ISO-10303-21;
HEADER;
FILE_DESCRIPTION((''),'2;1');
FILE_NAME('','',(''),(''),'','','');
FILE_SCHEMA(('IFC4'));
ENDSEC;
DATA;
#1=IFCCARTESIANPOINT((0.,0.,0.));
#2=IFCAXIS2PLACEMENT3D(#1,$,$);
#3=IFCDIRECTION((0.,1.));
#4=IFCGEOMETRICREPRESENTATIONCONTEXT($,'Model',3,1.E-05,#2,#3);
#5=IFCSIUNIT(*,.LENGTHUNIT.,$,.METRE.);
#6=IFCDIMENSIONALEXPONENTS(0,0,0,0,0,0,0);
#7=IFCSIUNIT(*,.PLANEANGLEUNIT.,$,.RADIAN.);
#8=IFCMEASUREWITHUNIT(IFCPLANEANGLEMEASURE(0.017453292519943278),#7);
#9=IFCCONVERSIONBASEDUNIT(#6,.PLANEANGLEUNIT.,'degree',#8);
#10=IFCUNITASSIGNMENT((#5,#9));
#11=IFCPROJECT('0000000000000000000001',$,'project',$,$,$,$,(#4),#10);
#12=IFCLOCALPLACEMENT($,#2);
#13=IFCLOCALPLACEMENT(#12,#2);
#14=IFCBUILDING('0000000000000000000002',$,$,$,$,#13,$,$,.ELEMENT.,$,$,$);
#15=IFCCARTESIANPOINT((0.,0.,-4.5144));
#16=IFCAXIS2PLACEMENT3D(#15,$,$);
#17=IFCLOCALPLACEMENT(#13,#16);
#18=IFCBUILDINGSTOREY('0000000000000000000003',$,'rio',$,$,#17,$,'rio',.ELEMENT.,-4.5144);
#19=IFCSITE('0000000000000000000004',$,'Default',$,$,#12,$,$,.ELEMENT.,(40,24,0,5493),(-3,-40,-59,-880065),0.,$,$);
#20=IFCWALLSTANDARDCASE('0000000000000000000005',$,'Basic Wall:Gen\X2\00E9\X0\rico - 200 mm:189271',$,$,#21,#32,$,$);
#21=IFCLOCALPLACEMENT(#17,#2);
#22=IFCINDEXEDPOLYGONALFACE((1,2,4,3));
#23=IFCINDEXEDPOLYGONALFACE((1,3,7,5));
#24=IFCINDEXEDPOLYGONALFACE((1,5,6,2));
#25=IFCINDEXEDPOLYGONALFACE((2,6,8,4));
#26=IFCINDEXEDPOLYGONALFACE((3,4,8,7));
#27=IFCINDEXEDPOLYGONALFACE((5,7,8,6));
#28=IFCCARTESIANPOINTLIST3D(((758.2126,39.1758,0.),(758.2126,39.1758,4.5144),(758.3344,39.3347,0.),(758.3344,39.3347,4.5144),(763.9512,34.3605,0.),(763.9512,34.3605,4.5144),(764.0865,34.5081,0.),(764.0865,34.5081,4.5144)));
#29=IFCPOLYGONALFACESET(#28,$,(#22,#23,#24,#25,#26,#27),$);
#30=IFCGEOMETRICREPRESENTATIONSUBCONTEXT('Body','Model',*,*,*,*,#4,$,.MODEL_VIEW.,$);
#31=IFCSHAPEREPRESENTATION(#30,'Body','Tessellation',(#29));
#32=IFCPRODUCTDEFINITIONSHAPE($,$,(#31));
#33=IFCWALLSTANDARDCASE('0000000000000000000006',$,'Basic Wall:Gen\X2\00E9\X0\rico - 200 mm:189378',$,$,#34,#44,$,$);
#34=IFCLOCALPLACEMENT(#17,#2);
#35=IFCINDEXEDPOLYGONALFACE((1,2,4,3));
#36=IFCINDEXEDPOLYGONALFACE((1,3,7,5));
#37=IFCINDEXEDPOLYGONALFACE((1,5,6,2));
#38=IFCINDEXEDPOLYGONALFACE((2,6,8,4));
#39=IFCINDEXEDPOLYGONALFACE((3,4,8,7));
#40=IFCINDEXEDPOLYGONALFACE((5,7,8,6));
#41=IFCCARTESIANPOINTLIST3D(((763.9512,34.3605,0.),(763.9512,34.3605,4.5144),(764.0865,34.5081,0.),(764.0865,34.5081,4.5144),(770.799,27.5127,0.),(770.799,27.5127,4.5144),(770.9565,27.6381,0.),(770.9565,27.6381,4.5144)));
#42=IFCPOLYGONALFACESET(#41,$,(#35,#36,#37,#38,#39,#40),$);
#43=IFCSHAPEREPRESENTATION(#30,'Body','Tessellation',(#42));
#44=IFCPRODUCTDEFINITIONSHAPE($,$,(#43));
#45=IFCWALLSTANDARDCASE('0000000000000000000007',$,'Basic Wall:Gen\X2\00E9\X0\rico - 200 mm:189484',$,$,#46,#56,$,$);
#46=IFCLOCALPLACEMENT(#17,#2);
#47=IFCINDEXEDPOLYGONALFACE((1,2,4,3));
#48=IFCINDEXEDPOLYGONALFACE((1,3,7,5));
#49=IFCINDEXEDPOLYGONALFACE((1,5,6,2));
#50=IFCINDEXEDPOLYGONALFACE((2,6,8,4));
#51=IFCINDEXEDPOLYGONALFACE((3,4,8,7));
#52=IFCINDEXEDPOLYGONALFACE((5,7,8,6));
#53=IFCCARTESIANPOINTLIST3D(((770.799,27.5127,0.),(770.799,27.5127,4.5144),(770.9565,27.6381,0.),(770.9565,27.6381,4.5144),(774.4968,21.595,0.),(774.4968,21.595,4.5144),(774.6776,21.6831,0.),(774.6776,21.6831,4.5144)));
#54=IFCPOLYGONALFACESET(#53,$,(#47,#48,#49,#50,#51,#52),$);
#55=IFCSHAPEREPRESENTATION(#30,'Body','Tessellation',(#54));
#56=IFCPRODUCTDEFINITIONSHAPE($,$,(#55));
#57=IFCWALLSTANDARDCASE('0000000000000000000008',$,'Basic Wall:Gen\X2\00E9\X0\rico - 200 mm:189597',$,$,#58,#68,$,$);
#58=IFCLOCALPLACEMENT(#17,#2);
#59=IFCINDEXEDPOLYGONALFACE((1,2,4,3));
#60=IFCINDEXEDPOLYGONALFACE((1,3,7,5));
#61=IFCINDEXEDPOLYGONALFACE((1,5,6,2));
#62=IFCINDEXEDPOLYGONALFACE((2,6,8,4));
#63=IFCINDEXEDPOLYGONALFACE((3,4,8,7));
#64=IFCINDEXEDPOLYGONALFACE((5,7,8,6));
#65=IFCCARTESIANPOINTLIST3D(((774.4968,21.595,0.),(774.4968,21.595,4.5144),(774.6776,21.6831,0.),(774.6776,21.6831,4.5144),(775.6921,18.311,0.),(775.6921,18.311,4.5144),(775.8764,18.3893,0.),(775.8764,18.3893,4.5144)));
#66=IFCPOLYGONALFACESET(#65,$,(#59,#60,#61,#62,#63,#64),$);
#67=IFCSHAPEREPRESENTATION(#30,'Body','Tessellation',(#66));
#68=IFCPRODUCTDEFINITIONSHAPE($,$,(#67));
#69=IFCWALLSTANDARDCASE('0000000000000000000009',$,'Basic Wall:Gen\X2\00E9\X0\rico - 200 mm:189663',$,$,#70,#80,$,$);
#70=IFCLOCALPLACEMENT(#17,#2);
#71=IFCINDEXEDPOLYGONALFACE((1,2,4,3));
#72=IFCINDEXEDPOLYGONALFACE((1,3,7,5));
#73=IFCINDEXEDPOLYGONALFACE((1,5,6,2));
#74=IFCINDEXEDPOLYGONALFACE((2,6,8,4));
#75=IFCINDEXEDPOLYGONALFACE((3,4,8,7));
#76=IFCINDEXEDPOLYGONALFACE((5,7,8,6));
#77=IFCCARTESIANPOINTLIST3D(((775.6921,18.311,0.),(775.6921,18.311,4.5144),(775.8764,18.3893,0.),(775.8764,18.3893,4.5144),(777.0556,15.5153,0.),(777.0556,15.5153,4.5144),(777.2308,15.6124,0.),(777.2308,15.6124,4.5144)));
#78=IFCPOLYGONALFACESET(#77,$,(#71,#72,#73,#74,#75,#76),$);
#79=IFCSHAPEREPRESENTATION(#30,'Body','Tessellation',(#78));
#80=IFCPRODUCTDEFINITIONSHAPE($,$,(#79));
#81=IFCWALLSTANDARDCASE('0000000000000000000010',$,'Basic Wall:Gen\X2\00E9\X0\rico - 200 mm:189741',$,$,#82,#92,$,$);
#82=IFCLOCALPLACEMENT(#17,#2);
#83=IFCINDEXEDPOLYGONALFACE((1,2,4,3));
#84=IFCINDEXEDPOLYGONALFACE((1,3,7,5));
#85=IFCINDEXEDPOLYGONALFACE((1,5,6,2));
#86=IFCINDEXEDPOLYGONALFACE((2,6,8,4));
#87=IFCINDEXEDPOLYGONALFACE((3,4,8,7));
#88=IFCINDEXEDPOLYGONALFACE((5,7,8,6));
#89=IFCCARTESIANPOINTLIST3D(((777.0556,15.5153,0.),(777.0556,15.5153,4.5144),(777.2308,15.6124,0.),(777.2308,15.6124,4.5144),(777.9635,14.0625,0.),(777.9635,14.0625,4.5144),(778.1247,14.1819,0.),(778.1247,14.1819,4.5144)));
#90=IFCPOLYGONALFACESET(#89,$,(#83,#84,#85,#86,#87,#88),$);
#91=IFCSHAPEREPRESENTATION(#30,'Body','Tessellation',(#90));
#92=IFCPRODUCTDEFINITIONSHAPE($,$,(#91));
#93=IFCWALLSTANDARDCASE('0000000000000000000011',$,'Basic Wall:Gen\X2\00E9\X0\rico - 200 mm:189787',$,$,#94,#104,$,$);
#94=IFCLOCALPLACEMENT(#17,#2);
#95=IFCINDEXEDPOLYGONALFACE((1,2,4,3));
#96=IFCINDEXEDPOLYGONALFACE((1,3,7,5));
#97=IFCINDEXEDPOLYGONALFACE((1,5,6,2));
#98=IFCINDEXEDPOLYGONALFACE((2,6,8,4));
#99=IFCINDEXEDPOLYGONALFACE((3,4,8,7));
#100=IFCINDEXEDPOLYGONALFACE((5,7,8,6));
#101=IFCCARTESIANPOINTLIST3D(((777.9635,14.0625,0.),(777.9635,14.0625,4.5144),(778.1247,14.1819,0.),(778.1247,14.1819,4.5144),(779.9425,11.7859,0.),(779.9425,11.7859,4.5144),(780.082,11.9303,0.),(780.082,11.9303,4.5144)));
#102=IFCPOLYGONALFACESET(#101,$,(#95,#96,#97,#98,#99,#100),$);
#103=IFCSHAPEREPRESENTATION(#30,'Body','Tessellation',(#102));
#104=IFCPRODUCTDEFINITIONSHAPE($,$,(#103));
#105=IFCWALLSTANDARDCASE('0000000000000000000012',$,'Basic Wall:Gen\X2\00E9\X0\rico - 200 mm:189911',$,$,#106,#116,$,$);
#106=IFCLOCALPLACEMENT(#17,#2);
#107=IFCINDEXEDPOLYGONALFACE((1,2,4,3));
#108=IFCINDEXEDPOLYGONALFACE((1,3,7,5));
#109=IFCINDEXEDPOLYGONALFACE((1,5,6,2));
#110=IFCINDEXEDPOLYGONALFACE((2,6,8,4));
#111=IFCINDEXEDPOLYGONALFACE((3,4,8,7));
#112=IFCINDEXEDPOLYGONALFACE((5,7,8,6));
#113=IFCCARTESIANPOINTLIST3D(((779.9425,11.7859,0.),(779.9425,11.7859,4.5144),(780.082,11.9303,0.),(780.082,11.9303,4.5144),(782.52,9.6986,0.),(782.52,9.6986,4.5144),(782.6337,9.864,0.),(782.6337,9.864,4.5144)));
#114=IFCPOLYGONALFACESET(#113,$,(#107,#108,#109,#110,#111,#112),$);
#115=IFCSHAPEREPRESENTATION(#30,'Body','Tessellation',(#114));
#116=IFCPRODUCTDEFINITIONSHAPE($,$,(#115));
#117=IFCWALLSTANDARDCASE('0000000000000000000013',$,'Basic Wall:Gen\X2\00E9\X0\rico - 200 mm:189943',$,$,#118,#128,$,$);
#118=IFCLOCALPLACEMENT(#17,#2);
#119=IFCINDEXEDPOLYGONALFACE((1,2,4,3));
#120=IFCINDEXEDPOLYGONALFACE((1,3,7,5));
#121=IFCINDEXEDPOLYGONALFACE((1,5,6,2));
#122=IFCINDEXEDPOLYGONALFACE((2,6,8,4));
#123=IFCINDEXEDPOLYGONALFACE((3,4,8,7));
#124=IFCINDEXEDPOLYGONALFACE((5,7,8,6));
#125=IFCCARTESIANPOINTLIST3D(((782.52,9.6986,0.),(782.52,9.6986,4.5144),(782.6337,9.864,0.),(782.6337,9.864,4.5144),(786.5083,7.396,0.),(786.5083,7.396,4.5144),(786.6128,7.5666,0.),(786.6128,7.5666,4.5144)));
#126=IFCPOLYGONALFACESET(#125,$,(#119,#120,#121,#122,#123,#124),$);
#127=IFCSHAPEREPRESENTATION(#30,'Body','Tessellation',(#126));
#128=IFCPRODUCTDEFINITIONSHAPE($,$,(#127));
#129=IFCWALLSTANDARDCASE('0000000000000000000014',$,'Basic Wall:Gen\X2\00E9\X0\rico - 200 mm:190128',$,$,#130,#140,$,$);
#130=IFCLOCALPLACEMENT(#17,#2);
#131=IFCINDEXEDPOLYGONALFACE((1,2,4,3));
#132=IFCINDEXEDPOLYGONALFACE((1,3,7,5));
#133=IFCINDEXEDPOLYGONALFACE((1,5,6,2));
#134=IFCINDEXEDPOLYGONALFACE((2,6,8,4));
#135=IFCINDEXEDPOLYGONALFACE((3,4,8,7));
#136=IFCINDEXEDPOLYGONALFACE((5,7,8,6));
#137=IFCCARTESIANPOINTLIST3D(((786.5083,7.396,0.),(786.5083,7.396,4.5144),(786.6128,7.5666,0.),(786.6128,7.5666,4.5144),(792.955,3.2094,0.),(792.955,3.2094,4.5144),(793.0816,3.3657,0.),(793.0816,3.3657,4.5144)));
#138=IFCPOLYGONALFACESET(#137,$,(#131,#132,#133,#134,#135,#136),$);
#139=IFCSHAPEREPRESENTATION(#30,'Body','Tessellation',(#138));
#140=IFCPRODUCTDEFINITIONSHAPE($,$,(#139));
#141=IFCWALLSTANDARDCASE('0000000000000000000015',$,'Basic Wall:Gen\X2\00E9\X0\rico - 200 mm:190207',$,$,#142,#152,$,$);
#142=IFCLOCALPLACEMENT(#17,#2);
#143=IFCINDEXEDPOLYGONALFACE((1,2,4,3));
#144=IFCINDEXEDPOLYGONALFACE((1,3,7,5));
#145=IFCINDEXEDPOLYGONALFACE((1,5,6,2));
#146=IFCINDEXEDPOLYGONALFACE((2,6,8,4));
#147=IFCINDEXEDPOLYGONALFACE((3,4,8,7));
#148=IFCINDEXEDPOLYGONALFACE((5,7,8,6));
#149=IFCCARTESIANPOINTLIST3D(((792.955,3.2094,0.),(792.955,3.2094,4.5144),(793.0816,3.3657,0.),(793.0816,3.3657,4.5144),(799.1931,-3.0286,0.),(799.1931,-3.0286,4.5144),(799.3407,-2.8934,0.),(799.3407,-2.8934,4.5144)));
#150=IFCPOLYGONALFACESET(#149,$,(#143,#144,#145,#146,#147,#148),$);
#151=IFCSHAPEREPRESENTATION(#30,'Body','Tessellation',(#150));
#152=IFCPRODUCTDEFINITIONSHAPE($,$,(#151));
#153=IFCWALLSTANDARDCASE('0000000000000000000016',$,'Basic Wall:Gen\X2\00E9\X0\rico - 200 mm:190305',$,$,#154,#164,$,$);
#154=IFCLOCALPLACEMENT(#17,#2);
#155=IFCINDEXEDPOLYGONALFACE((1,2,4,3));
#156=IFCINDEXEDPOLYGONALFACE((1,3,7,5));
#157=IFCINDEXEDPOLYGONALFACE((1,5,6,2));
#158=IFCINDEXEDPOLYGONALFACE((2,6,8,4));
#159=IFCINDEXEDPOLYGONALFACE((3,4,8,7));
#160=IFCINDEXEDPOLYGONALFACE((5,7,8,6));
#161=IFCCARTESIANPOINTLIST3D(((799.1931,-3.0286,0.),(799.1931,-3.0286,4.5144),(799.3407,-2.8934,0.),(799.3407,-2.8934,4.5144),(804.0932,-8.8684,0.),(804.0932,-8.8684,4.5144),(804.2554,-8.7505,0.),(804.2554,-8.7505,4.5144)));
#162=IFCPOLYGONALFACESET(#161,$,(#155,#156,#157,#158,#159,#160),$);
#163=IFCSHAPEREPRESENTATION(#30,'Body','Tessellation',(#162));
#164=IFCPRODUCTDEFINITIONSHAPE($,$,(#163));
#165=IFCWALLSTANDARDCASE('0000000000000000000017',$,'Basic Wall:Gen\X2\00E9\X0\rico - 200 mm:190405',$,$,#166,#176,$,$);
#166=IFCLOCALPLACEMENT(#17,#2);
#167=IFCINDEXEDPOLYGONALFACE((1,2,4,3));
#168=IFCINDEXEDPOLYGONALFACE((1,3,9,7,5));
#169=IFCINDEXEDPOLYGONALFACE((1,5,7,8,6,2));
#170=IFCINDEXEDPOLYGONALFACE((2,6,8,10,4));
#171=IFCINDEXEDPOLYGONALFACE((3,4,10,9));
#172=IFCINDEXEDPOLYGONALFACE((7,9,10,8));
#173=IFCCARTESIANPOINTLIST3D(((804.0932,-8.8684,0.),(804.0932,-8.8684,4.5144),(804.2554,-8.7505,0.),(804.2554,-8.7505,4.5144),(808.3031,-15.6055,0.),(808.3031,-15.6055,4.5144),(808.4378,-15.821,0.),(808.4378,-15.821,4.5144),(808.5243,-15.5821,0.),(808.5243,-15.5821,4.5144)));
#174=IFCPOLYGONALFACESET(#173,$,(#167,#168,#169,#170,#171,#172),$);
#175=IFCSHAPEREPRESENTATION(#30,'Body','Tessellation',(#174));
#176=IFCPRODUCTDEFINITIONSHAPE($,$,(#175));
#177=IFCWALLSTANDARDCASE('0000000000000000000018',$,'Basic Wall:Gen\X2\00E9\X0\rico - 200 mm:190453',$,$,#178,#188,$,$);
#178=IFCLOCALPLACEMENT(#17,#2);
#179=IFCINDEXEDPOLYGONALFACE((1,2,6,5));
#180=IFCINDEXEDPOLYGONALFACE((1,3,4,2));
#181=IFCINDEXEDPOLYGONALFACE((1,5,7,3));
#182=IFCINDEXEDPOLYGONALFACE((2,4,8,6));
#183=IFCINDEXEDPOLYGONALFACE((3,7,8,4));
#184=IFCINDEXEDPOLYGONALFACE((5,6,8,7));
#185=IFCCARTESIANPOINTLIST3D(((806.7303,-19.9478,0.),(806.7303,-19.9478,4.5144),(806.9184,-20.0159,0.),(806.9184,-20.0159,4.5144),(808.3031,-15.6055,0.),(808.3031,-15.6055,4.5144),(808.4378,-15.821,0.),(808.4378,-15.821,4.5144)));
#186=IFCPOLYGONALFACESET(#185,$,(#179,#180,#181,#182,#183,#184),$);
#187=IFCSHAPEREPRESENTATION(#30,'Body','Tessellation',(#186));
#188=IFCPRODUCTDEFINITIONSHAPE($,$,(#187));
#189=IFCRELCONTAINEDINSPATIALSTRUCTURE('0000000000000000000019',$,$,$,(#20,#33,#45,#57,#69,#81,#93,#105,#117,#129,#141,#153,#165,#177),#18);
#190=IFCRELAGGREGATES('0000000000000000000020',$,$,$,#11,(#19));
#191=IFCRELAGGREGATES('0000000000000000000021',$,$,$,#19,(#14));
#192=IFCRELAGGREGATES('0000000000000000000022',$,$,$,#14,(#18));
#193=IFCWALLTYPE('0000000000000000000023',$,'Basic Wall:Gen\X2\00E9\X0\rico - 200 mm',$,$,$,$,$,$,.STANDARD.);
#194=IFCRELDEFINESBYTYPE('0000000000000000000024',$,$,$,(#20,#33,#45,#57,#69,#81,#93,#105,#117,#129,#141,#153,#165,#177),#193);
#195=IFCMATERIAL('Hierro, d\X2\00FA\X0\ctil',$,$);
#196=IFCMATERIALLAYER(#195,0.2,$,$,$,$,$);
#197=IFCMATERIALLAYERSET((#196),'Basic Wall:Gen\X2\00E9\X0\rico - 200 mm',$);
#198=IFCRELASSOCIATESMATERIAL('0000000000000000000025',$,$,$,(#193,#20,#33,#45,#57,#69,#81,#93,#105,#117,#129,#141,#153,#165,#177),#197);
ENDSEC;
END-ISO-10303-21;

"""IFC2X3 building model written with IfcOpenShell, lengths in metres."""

from ifc_helpers import new_model, entity, si_unit, converted_unit, direction, frame, origin, place, context, subcontext, project, spatial, polyline, outline, extrude, material, layer, layer_set, layer_usage, type_object, element, save


model = new_model("IFC2X3")

# Units and contexts
model_context = context("Model", 3, precision=1e-05, world=origin(), true_north=direction((0.0, 1.0)))
body_context = subcontext(model_context, "Body", "Model", "MODEL_VIEW")
ifc_project = project(units=[si_unit("LENGTHUNIT", "METRE"), converted_unit("PLANEANGLEUNIT", "degree", entity("IfcPlaneAngleMeasure", 0.017453292519943278), si_unit("PLANEANGLEUNIT", "RADIAN"), dimensions=[0, 0, 0, 0, 0, 0, 0])], contexts=[model_context])

# Site, building, storey
site_placement = place(None, origin())
site = spatial("IfcSite", under=ifc_project, at=site_placement, Name="Default", CompositionType="ELEMENT", RefLatitude=(40, 24, 0, 5493), RefLongitude=(-3, -40, -59, -880065), RefElevation=0.0)
building_placement = place(site_placement, origin())
building = spatial("IfcBuilding", under=site, at=building_placement, CompositionType="ELEMENT")
storey_placement = place(building_placement, frame((0.0, 0.0, -4.5144)))
storey = spatial("IfcBuildingStorey", under=building, at=storey_placement, Name="rio", LongName="rio", CompositionType="ELEMENT", Elevation=-4.5144)

# Walls
ifc_material = material(Name="Hierro, dúctil")
ifc_layer = layer(ifc_material, 0.2)
ifc_layer_set = layer_set([ifc_layer], Name="Basic Wall:Genérico - 200 mm")
wall_type = type_object("IfcWallType", Name="Basic Wall:Genérico - 200 mm", PredefinedType="STANDARD", material=ifc_layer_set)
ifc_layer_usage_1 = layer_usage(ifc_layer_set, "AXIS2", "NEGATIVE", 0.1)
wall_1_placement = place(storey_placement, frame((758.2702, 39.2581, 0.0), z_axis=(0.0, 0.0, 1.0), x_axis=(0.766044, -0.642788, 0.0)))
element("IfcWallStandardCase", 1, at=wall_1_placement, inside=storey, type_object=wall_type, material=ifc_layer_usage_1, Name="Basic Wall:Genérico - 200 mm:189271", context=body_context, shape_type="SweptSolid", body=[
    extrude(outline(polyline([(7.5, -0.1), (7.5087, 0.1), (0.0, 0.1), (0.0087, -0.1), (7.5, -0.1)])), origin(), (0.0, 0.0, 1.0), 4.5144),
])
ifc_layer_usage_2 = layer_usage(ifc_layer_set, "AXIS2", "NEGATIVE", 0.1)
wall_2_placement = place(storey_placement, frame((764.0157, 34.4374, 0.0), z_axis=(0.0, 0.0, 1.0), x_axis=(0.707107, -0.707107, 0.0)))
element("IfcWallStandardCase", 2, at=wall_2_placement, inside=storey, type_object=wall_type, material=ifc_layer_usage_2, Name="Basic Wall:Genérico - 200 mm:189378", context=body_context, shape_type="SweptSolid", body=[
    extrude(outline(polyline([(9.693, -0.1), (9.7158, 0.1), (0.0, 0.1), (0.0087, -0.1), (9.693, -0.1)])), origin(), (0.0, 0.0, 1.0), 4.5144),
])
ifc_layer_usage_3 = layer_usage(ifc_layer_set, "AXIS2", "NEGATIVE", 0.1)
wall_3_placement = place(storey_placement, frame((770.8717, 27.5851, 0.0), z_axis=(0.0, 0.0, 1.0), x_axis=(0.529919, -0.848048, 0.0)))
element("IfcWallStandardCase", 3, at=wall_3_placement, inside=storey, type_object=wall_type, material=ifc_layer_usage_3, Name="Basic Wall:Genérico - 200 mm:189484", context=body_context, shape_type="SweptSolid", body=[
    extrude(outline(polyline([(7.0009, -0.1), (7.0219, 0.1), (0.0, 0.1), (0.0228, -0.1), (7.0009, -0.1)])), origin(), (0.0, 0.0, 1.0), 4.5144),
])
ifc_layer_usage_4 = layer_usage(ifc_layer_set, "AXIS2", "NEGATIVE", 0.1)
wall_4_placement = place(storey_placement, frame((774.5836, 21.6489, 0.0), z_axis=(0.0, 0.0, 1.0), x_axis=(0.34202, -0.939693, 0.0)))
element("IfcWallStandardCase", 4, at=wall_4_placement, inside=storey, type_object=wall_type, material=ifc_layer_usage_4, Name="Basic Wall:Genérico - 200 mm:189597", context=body_context, shape_type="SweptSolid", body=[
    extrude(outline(polyline([(3.5158, -0.1), (3.5053, 0.1), (0.0, 0.1), (0.021, -0.1), (3.5158, -0.1)])), origin(), (0.0, 0.0, 1.0), 4.5144),
])
ifc_layer_usage_5 = layer_usage(ifc_layer_set, "AXIS2", "NEGATIVE", 0.1)
wall_5_placement = place(storey_placement, frame((775.782, 18.3549, 0.0), z_axis=(0.0, 0.0, 1.0), x_axis=(0.438371, -0.898794, 0.0)))
element("IfcWallStandardCase", 5, at=wall_5_placement, inside=storey, type_object=wall_type, material=ifc_layer_usage_5, Name="Basic Wall:Genérico - 200 mm:189663", context=body_context, shape_type="SweptSolid", body=[
    extrude(outline(polyline([(3.1105, -0.1), (3.1, 0.1), (0.0105, 0.1), (0.0, -0.1), (3.1105, -0.1)])), origin(), (0.0, 0.0, 1.0), 4.5144),
])
ifc_layer_usage_6 = layer_usage(ifc_layer_set, "AXIS2", "NEGATIVE", 0.1)
wall_6_placement = place(storey_placement, frame((777.1404, 15.5683, 0.0), z_axis=(0.0, 0.0, 1.0), x_axis=(0.529919, -0.848048, 0.0)))
element("IfcWallStandardCase", 6, at=wall_6_placement, inside=storey, type_object=wall_type, material=ifc_layer_usage_6, Name="Basic Wall:Genérico - 200 mm:189741", context=body_context, shape_type="SweptSolid", body=[
    extrude(outline(polyline([(1.7131, -0.1), (1.6974, 0.1), (0.0105, 0.1), (0.0, -0.1), (1.7131, -0.1)])), origin(), (0.0, 0.0, 1.0), 4.5144),
])
ifc_layer_usage_7 = layer_usage(ifc_layer_set, "AXIS2", "NEGATIVE", 0.1)
wall_7_placement = place(storey_placement, frame((778.0389, 14.1281, 0.0), z_axis=(0.0, 0.0, 1.0), x_axis=(0.656059, -0.75471, 0.0)))
element("IfcWallStandardCase", 7, at=wall_7_placement, inside=storey, type_object=wall_type, material=ifc_layer_usage_7, Name="Basic Wall:Genérico - 200 mm:189787", context=body_context, shape_type="SweptSolid", body=[
    extrude(outline(polyline([(3.0166, -0.1), (2.9991, 0.1), (0.0157, 0.1), (0.0, -0.1), (3.0166, -0.1)])), origin(), (0.0, 0.0, 1.0), 4.5144),
])
ifc_layer_usage_8 = layer_usage(ifc_layer_set, "AXIS2", "NEGATIVE", 0.1)
wall_8_placement = place(storey_placement, frame((780.0055, 11.8636, 0.0), z_axis=(0.0, 0.0, 1.0), x_axis=(0.777146, -0.62932, 0.0)))
element("IfcWallStandardCase", 8, at=wall_8_placement, inside=storey, type_object=wall_type, material=ifc_layer_usage_8, Name="Basic Wall:Genérico - 200 mm:189911", context=body_context, shape_type="SweptSolid", body=[
    extrude(outline(polyline([(3.3166, -0.1), (3.3009, 0.1), (0.0175, 0.1), (0.0, -0.1), (3.3166, -0.1)])), origin(), (0.0, 0.0, 1.0), 4.5144),
])
ifc_layer_usage_9 = layer_usage(ifc_layer_set, "AXIS2", "NEGATIVE", 0.1)
wall_9_placement = place(storey_placement, frame((782.57, 9.7852, 0.0), z_axis=(0.0, 0.0, 1.0), x_axis=(0.866025, -0.5, 0.0)))
element("IfcWallStandardCase", 9, at=wall_9_placement, inside=storey, type_object=wall_type, material=ifc_layer_usage_9, Name="Basic Wall:Genérico - 200 mm:189943", context=body_context, shape_type="SweptSolid", body=[
    extrude(outline(polyline([(4.6053, -0.1), (4.6105, 0.1), (0.0157, 0.1), (0.0, -0.1), (4.6053, -0.1)])), origin(), (0.0, 0.0, 1.0), 4.5144),
])
ifc_layer_usage_10 = layer_usage(ifc_layer_set, "AXIS2", "NEGATIVE", 0.1)
wall_10_placement = place(storey_placement, frame((786.5584, 7.4827, 0.0), z_axis=(0.0, 0.0, 1.0), x_axis=(0.838671, -0.544639, 0.0)))
element("IfcWallStandardCase", 10, at=wall_10_placement, inside=storey, type_object=wall_type, material=ifc_layer_usage_10, Name="Basic Wall:Genérico - 200 mm:190128", context=body_context, shape_type="SweptSolid", body=[
    extrude(outline(polyline([(7.6921, -0.1), (7.7131, 0.1), (0.0, 0.1), (0.0052, -0.1), (7.6921, -0.1)])), origin(), (0.0, 0.0, 1.0), 4.5144),
])
ifc_layer_usage_11 = layer_usage(ifc_layer_set, "AXIS2", "NEGATIVE", 0.1)
wall_11_placement = place(storey_placement, frame((793.0109, 3.295, 0.0), z_axis=(0.0, 0.0, 1.0), x_axis=(0.707107, -0.707107, 0.0)))
element("IfcWallStandardCase", 11, at=wall_11_placement, inside=storey, type_object=wall_type, material=ifc_layer_usage_11, Name="Basic Wall:Genérico - 200 mm:190207", context=body_context, shape_type="SweptSolid", body=[
    extrude(outline(polyline([(8.843, -0.1), (8.8517, 0.1), (0.0, 0.1), (0.021, -0.1), (8.843, -0.1)])), origin(), (0.0, 0.0, 1.0), 4.5144),
])
ifc_layer_usage_12 = layer_usage(ifc_layer_set, "AXIS2", "NEGATIVE", 0.1)
wall_12_placement = place(storey_placement, frame((799.2641, -2.9577, 0.0), z_axis=(0.0, 0.0, 1.0), x_axis=(0.642788, -0.766044, 0.0)))
element("IfcWallStandardCase", 12, at=wall_12_placement, inside=storey, type_object=wall_type, material=ifc_layer_usage_12, Name="Basic Wall:Genérico - 200 mm:190305", context=body_context, shape_type="SweptSolid", body=[
    extrude(outline(polyline([(7.632, -0.1), (7.6459, 0.1), (0.0, 0.1), (0.0087, -0.1), (7.632, -0.1)])), origin(), (0.0, 0.0, 1.0), 4.5144),
])
ifc_layer_usage_13 = layer_usage(ifc_layer_set, "AXIS2", "NEGATIVE", 0.1)
wall_13_placement = place(storey_placement, frame((804.1706, -8.8035, 0.0), z_axis=(0.0, 0.0, 1.0), x_axis=(0.529919, -0.848048, 0.0)))
element("IfcWallStandardCase", 13, at=wall_13_placement, inside=storey, type_object=wall_type, material=ifc_layer_usage_13, Name="Basic Wall:Genérico - 200 mm:190405", context=body_context, shape_type="SweptSolid", body=[
    extrude(outline(polyline([(8.2124, -0.1), (8.0557, 0.1), (0.0, 0.1), (0.014, -0.1), (7.9583, -0.1), (8.2124, -0.1)])), origin(), (0.0, 0.0, 1.0), 4.5144),
])
ifc_layer_usage_14 = layer_usage(ifc_layer_set, "AXIS2", "NEGATIVE", 0.1)
wall_14_placement = place(storey_placement, frame((808.3971, -15.6396, 0.0), z_axis=(0.0, 0.0, 1.0), x_axis=(-0.340549, -0.940227, 0.0)))
element("IfcWallStandardCase", 14, at=wall_14_placement, inside=storey, type_object=wall_type, material=ifc_layer_usage_14, Name="Basic Wall:Genérico - 200 mm:190453", context=body_context, shape_type="SweptSolid", body=[
    extrude(outline(polyline([(4.6184, -0.1), (4.6184, 0.1), (0.1568, 0.1), (0.0, -0.1), (4.6184, -0.1)])), origin(), (0.0, 0.0, 1.0), 4.5144),
])

save(model, "model.ifc")
